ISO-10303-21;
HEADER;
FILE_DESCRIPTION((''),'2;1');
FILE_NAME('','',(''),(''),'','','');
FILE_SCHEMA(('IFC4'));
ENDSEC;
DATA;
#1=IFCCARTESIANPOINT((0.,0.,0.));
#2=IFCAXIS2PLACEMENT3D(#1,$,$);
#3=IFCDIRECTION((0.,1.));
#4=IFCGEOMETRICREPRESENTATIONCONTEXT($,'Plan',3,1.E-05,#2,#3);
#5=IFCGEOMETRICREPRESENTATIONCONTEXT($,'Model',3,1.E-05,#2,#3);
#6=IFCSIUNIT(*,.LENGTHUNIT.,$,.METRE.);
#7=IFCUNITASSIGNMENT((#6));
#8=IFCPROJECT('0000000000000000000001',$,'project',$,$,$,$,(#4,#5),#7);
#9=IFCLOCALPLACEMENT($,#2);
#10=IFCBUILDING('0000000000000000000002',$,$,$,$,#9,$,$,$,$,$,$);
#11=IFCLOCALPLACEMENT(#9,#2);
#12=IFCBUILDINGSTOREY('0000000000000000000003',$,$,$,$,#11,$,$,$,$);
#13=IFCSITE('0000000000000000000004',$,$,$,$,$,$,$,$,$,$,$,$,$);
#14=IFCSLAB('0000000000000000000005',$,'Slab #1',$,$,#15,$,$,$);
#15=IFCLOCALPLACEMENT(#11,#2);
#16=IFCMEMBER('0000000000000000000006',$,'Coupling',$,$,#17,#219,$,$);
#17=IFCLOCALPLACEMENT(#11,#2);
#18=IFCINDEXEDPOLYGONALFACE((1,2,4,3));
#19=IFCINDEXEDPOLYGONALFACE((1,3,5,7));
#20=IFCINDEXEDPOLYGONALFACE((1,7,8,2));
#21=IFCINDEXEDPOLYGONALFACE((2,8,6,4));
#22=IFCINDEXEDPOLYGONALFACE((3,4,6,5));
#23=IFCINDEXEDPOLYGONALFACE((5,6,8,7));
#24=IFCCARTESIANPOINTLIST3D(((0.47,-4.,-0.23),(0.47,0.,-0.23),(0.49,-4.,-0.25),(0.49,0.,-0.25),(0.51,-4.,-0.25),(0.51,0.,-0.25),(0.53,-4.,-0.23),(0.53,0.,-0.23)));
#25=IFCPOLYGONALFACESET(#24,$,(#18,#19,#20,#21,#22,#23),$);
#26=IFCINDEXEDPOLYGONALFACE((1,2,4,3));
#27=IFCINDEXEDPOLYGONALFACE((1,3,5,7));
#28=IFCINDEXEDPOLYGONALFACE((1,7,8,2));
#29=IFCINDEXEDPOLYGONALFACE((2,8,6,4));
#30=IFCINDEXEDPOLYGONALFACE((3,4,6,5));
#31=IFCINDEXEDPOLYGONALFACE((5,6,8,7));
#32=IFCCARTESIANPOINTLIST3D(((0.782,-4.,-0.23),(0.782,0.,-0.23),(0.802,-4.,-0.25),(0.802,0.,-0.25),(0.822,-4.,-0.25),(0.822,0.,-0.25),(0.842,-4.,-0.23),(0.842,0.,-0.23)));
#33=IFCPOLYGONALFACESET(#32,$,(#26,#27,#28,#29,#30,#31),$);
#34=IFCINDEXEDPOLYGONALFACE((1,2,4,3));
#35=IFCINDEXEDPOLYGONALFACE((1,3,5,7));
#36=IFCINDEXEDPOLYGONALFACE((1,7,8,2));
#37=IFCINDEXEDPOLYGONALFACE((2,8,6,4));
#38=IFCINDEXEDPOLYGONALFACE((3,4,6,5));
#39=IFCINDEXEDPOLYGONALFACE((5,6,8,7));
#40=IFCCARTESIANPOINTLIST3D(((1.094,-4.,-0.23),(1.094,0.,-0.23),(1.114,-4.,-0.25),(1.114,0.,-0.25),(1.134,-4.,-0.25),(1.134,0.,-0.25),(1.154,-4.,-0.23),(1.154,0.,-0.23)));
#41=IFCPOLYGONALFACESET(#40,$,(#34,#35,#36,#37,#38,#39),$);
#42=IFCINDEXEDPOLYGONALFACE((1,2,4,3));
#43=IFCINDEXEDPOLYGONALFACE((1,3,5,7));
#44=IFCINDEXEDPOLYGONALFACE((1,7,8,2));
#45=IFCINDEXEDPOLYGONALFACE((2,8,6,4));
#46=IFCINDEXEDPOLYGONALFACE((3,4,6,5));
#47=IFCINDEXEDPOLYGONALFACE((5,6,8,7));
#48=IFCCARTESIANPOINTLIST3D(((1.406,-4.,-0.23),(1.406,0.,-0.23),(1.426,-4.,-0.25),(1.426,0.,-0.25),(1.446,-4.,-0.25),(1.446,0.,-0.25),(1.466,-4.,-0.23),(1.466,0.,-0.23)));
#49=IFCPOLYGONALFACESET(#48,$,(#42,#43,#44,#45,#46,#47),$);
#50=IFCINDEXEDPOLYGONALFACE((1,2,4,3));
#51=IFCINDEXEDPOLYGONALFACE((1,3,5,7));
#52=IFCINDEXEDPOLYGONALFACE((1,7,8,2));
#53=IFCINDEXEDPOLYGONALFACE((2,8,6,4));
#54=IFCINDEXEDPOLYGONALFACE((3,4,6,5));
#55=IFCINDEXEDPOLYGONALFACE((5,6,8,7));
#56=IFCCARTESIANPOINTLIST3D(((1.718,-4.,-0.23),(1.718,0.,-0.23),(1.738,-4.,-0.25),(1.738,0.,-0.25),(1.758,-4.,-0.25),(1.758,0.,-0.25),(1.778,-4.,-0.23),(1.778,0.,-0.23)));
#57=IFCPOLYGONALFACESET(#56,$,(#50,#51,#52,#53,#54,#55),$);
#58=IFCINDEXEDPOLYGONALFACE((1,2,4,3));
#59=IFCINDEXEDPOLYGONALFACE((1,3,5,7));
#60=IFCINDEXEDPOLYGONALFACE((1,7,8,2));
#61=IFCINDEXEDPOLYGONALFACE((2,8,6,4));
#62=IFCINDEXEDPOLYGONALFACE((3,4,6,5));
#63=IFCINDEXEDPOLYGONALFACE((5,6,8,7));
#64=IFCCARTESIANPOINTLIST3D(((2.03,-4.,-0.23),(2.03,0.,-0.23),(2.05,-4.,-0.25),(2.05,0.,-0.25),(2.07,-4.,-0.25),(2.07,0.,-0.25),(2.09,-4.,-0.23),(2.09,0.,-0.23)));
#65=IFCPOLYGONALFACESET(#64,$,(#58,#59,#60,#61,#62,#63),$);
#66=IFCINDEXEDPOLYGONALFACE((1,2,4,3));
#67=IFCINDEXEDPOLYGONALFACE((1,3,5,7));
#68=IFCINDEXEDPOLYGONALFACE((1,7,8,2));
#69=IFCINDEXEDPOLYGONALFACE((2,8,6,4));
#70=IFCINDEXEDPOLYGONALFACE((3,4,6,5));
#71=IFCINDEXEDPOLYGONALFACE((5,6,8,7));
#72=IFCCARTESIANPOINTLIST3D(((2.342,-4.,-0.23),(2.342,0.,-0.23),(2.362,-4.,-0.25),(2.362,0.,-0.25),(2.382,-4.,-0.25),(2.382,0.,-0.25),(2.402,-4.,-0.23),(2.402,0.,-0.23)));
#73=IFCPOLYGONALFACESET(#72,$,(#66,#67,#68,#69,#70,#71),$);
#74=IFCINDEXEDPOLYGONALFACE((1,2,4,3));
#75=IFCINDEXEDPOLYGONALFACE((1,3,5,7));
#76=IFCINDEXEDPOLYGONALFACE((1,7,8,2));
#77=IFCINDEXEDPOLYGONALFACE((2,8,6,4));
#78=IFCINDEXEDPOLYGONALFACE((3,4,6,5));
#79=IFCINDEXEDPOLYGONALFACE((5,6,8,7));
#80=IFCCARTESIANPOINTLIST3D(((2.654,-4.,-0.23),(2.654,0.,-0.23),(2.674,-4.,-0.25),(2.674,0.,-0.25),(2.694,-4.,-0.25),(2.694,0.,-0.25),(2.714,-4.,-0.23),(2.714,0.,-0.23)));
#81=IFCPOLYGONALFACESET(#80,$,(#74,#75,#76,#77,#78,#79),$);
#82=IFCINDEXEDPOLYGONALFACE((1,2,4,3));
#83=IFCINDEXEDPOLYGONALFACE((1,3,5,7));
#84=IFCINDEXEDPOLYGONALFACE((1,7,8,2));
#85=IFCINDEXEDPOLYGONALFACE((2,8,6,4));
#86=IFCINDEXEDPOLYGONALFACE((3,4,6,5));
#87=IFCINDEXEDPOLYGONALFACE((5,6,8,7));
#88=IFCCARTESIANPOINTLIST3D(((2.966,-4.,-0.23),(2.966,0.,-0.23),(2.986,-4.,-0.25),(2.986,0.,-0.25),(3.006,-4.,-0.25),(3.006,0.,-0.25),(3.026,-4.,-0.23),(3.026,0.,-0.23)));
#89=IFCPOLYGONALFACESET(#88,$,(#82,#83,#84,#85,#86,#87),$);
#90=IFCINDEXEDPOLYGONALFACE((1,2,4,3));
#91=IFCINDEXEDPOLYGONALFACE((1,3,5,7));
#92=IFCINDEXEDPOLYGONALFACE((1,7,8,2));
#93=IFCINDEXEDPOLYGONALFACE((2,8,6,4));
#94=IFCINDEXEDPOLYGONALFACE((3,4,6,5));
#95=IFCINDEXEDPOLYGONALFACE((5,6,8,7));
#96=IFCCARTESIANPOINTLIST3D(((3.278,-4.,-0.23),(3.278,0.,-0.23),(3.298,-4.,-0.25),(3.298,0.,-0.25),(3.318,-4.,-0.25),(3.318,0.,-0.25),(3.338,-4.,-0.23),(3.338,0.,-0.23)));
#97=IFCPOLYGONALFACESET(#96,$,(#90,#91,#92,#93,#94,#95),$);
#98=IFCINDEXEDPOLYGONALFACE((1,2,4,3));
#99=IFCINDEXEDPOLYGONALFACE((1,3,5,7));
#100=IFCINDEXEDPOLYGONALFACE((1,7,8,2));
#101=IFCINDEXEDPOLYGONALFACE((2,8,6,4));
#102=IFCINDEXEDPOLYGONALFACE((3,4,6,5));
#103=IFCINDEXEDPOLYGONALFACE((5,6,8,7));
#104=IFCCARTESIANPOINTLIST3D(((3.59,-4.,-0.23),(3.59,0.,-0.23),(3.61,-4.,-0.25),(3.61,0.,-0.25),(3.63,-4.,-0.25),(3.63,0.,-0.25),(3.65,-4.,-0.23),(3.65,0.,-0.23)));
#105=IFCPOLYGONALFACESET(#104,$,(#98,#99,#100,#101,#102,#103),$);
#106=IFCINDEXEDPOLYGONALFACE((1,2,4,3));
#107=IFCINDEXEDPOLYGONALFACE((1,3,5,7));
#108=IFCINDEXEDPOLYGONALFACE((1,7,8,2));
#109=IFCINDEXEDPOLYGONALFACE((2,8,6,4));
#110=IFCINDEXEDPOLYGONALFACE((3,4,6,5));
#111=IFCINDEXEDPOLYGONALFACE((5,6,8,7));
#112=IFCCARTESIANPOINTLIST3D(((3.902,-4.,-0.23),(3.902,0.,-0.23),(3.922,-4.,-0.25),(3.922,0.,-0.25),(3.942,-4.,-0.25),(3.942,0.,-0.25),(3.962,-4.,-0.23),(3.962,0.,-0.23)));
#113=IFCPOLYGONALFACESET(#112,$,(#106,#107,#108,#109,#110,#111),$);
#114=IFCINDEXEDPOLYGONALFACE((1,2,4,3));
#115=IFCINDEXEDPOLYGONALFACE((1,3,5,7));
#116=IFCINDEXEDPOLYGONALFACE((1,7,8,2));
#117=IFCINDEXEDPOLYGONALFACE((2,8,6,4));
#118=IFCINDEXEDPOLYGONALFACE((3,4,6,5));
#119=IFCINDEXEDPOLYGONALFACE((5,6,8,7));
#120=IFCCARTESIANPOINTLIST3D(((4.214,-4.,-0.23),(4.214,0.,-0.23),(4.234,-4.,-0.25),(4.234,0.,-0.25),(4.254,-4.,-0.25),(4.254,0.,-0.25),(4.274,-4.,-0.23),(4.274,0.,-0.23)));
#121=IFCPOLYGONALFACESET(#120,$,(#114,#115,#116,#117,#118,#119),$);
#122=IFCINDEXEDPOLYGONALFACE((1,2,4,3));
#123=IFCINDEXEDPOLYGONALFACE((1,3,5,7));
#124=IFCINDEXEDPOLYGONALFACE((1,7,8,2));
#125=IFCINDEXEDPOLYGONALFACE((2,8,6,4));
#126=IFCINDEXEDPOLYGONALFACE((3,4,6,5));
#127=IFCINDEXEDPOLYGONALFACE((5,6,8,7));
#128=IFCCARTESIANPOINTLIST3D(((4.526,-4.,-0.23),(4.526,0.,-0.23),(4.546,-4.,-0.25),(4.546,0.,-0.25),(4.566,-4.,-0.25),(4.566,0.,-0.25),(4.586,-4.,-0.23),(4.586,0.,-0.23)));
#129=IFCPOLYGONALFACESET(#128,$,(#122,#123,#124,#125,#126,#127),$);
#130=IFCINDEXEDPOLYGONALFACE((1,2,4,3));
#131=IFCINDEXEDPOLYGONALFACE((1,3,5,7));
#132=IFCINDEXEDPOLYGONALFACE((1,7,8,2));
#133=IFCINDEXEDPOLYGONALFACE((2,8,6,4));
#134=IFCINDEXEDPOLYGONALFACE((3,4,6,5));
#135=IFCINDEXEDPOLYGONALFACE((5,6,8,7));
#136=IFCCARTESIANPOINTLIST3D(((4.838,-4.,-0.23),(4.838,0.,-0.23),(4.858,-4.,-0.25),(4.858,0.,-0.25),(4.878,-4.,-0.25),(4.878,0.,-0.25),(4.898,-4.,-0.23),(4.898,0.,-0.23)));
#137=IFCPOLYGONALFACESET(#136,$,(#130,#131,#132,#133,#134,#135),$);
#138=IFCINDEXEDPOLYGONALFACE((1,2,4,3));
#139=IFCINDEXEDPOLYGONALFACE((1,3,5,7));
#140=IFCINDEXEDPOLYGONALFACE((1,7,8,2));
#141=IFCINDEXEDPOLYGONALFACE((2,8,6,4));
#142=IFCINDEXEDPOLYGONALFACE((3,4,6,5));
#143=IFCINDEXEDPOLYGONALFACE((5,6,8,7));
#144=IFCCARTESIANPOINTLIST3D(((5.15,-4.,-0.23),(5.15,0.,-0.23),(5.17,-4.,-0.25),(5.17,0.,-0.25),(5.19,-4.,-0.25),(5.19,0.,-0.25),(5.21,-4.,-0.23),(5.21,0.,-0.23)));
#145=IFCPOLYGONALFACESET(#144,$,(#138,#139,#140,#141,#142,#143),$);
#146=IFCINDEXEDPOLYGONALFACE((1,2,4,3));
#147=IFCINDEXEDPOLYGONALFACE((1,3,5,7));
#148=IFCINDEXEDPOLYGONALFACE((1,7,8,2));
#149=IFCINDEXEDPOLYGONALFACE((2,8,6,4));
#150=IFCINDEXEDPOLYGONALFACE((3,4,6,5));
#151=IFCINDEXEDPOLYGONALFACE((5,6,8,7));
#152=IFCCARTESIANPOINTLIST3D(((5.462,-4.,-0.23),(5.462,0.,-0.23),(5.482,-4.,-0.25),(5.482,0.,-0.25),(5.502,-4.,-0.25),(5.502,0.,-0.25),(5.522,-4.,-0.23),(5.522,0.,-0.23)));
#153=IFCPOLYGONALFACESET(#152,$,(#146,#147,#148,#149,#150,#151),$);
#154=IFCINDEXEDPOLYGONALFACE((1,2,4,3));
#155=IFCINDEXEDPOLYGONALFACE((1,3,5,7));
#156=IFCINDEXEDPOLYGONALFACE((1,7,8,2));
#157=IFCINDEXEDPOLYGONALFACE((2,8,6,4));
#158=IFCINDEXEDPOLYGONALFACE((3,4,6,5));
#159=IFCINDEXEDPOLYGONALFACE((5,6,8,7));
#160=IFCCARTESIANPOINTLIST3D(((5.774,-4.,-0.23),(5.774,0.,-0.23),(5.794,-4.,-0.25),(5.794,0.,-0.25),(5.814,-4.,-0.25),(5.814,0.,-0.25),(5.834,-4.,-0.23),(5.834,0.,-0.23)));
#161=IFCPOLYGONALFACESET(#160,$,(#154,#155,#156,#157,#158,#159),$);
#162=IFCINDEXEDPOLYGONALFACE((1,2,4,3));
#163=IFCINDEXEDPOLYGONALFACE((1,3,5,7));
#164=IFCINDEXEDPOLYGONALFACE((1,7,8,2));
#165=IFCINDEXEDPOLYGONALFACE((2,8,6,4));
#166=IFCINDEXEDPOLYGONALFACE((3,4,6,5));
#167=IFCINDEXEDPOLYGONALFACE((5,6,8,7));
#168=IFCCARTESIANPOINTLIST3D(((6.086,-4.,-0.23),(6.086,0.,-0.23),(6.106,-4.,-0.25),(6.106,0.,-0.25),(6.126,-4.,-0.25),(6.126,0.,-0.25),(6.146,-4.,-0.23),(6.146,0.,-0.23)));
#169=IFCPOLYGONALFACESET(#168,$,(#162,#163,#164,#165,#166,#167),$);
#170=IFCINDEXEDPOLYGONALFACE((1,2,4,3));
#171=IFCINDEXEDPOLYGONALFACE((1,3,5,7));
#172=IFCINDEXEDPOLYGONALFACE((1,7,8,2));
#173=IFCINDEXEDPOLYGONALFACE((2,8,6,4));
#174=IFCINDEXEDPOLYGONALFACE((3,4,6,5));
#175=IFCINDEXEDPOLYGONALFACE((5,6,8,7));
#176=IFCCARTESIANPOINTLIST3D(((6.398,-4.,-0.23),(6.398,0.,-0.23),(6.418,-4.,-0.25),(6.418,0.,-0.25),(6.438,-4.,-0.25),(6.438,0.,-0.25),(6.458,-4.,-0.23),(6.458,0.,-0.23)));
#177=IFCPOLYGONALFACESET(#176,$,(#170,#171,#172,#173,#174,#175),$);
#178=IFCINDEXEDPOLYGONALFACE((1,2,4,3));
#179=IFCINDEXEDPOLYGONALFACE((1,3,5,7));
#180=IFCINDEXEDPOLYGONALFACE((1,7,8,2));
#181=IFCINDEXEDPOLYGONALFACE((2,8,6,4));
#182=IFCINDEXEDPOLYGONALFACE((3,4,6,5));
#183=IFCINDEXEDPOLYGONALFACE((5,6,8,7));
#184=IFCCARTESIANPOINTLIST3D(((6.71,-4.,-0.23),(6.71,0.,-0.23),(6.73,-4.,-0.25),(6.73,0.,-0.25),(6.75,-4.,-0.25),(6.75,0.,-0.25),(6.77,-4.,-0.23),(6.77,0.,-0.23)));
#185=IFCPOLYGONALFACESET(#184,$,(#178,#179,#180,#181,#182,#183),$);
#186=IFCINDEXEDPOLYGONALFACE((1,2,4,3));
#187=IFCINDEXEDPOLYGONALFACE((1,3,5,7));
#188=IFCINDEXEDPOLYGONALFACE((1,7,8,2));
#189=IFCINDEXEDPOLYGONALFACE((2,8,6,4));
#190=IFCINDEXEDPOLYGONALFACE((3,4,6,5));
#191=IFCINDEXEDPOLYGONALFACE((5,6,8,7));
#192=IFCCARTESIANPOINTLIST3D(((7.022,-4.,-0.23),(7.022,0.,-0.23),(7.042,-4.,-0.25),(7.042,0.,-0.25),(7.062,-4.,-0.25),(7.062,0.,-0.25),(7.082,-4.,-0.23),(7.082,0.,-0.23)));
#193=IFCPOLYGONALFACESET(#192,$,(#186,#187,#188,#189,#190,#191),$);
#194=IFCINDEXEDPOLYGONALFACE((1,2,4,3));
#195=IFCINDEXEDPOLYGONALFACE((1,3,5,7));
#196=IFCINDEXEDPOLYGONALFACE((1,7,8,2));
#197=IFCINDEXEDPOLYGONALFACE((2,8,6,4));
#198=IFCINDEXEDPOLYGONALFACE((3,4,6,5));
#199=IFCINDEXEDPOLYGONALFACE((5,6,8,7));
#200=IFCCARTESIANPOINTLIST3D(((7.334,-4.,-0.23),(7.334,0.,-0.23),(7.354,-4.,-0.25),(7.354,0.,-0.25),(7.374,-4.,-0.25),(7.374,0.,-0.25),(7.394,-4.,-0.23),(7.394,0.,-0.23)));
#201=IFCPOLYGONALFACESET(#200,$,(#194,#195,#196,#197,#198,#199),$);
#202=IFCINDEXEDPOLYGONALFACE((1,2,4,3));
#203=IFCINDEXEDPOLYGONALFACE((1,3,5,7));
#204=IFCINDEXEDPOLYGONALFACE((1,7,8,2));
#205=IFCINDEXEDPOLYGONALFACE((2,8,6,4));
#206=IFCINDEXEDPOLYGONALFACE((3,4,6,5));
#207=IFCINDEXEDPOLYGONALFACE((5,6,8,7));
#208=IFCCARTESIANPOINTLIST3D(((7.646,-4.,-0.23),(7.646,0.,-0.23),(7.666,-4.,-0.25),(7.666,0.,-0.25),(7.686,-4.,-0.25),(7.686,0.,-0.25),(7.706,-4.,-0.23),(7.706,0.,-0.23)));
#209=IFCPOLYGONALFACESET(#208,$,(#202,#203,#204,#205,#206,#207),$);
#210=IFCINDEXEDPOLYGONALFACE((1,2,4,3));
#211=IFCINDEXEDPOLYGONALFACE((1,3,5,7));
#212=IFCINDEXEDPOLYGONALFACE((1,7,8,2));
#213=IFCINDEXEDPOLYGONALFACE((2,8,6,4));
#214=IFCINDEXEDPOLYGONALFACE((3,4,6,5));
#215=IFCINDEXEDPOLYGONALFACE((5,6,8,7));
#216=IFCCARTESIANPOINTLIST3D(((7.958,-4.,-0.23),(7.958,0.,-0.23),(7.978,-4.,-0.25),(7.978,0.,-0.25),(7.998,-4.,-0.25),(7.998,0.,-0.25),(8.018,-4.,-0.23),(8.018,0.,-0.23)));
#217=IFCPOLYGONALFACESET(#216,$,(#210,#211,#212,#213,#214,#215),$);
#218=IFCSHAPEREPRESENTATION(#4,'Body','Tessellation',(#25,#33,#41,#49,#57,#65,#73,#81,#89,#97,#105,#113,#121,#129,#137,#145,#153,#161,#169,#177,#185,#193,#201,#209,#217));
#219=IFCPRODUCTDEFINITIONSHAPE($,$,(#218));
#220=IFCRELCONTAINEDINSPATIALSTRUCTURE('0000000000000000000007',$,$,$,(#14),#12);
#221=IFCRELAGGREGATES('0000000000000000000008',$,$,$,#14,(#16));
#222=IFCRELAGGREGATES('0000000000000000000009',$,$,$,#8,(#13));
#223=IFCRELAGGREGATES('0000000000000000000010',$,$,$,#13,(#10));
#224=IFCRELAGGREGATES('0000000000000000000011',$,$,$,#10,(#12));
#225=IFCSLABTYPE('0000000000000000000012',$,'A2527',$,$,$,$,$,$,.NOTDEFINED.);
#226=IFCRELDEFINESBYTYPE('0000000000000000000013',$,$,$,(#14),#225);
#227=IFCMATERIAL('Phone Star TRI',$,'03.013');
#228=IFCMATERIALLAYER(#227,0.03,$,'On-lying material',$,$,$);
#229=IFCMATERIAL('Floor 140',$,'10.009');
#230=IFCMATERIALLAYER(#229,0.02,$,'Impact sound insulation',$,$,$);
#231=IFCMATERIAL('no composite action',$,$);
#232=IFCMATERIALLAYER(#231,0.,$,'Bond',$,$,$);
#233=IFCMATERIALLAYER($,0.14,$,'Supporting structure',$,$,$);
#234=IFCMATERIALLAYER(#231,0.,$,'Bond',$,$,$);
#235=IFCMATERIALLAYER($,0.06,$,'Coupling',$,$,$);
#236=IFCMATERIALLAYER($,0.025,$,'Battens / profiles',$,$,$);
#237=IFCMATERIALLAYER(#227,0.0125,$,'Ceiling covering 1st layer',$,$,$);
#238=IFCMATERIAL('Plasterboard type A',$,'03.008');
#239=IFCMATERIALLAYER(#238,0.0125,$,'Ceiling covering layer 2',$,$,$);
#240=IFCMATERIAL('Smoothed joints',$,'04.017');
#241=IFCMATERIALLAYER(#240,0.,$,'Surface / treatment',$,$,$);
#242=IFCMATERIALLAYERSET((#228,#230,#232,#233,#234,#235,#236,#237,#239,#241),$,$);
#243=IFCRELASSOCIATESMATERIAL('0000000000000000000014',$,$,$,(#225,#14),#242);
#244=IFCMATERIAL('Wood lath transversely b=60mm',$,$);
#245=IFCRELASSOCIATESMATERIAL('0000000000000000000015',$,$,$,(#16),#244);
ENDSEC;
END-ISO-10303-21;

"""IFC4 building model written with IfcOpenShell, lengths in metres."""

from ifc_helpers import new_model, si_unit, direction, frame, origin, place, context, project, spatial, polyline, outline, extrude, material, layer, layer_set, type_object, element, aggregate, save


model = new_model("IFC4")

# Units and contexts
plan_context = context("Plan", 3, precision=1e-05, world=origin(), true_north=direction((0.0, 1.0)))
model_context = context("Model", 3, precision=1e-05, world=origin(), true_north=direction((0.0, 1.0)))
ifc_project = project(units=[si_unit("LENGTHUNIT", "METRE")], contexts=[plan_context, model_context])

# Site, building, storey
site = spatial("IfcSite", under=ifc_project)
building_placement = place(None, origin())
building = spatial("IfcBuilding", under=site, at=building_placement)
storey_placement = place(building_placement, origin())
storey = spatial("IfcBuildingStorey", under=building, at=storey_placement)

# Slab, member
ifc_material_1 = material(Name="Phone Star TRI", Category="03.013")
ifc_layer_1 = layer(ifc_material_1, 0.03, Name="On-lying material")
ifc_material_2 = material(Name="Floor 140", Category="10.009")
ifc_layer_2 = layer(ifc_material_2, 0.02, Name="Impact sound insulation")
ifc_material_3 = material(Name="no composite action")
ifc_layer_3 = layer(ifc_material_3, 0.0, Name="Bond")
ifc_layer_4 = layer(None, 0.14, Name="Supporting structure")
ifc_layer_5 = layer(ifc_material_3, 0.0, Name="Bond")
ifc_layer_6 = layer(None, 0.06, Name="Coupling")
ifc_layer_7 = layer(None, 0.025, Name="Battens / profiles")
ifc_layer_8 = layer(ifc_material_1, 0.0125, Name="Ceiling covering 1st layer")
ifc_material_4 = material(Name="Plasterboard type A", Category="03.008")
ifc_layer_9 = layer(ifc_material_4, 0.0125, Name="Ceiling covering layer 2")
ifc_material_5 = material(Name="Smoothed joints", Category="04.017")
ifc_layer_10 = layer(ifc_material_5, 0.0, Name="Surface / treatment")
ifc_layer_set = layer_set([ifc_layer_1, ifc_layer_2, ifc_layer_3, ifc_layer_4, ifc_layer_5, ifc_layer_6, ifc_layer_7, ifc_layer_8, ifc_layer_9, ifc_layer_10])
slab_type = type_object("IfcSlabType", Name="A2527", PredefinedType="NOTDEFINED", material=ifc_layer_set)
slab_placement = place(None, frame((0.0, 0.0, 0.0), z_axis=(0.0, 0.0, -1.0), x_axis=(1.0, 0.0, 0.0)))
slab = element("IfcSlab", 1, at=slab_placement, inside=storey, type_object=slab_type, material=ifc_layer_set, Name="Slab #1")
ifc_material_6 = material(Name="Wood lath transversely b=60mm")
member_1_placement = place(slab_placement, origin())
member_1 = element("IfcMember", 2, at=member_1_placement, material=ifc_material_6, Name="Coupling", context=plan_context, shape_type="SweptSolid", body=[
    extrude(outline(polyline([(0.0, 0.0), (0.06, 0.0), (0.04, 0.02), (0.02, 0.02), (0.0, 0.0)])), frame((0.47, 4.0, 0.23), z_axis=(0.0, -1.0, 0.0), x_axis=(1.0, 0.0, 0.0)), (0.0, 0.0, 1.0), 4.0),
    extrude(outline(polyline([(0.0, 0.0), (0.06, 0.0), (0.04, 0.02), (0.02, 0.02), (0.0, 0.0)])), frame((0.782, 4.0, 0.23), z_axis=(0.0, -1.0, 0.0), x_axis=(1.0, 0.0, 0.0)), (0.0, 0.0, 1.0), 4.0),
    extrude(outline(polyline([(0.0, 0.0), (0.06, 0.0), (0.04, 0.02), (0.02, 0.02), (0.0, 0.0)])), frame((1.094, 4.0, 0.23), z_axis=(0.0, -1.0, 0.0), x_axis=(1.0, 0.0, 0.0)), (0.0, 0.0, 1.0), 4.0),
    extrude(outline(polyline([(0.0, 0.0), (0.06, 0.0), (0.04, 0.02), (0.02, 0.02), (0.0, 0.0)])), frame((1.406, 4.0, 0.23), z_axis=(0.0, -1.0, 0.0), x_axis=(1.0, 0.0, 0.0)), (0.0, 0.0, 1.0), 4.0),
    extrude(outline(polyline([(0.0, 0.0), (0.06, 0.0), (0.04, 0.02), (0.02, 0.02), (0.0, 0.0)])), frame((1.718, 4.0, 0.23), z_axis=(0.0, -1.0, 0.0), x_axis=(1.0, 0.0, 0.0)), (0.0, 0.0, 1.0), 4.0),
    extrude(outline(polyline([(0.0, 0.0), (0.06, 0.0), (0.04, 0.02), (0.02, 0.02), (0.0, 0.0)])), frame((2.03, 4.0, 0.23), z_axis=(0.0, -1.0, 0.0), x_axis=(1.0, 0.0, 0.0)), (0.0, 0.0, 1.0), 4.0),
    extrude(outline(polyline([(0.0, 0.0), (0.06, 0.0), (0.04, 0.02), (0.02, 0.02), (0.0, 0.0)])), frame((2.342, 4.0, 0.23), z_axis=(0.0, -1.0, 0.0), x_axis=(1.0, 0.0, 0.0)), (0.0, 0.0, 1.0), 4.0),
    extrude(outline(polyline([(0.0, 0.0), (0.06, 0.0), (0.04, 0.02), (0.02, 0.02), (0.0, 0.0)])), frame((2.654, 4.0, 0.23), z_axis=(0.0, -1.0, 0.0), x_axis=(1.0, 0.0, 0.0)), (0.0, 0.0, 1.0), 4.0),
    extrude(outline(polyline([(0.0, 0.0), (0.06, 0.0), (0.04, 0.02), (0.02, 0.02), (0.0, 0.0)])), frame((2.966, 4.0, 0.23), z_axis=(0.0, -1.0, 0.0), x_axis=(1.0, 0.0, 0.0)), (0.0, 0.0, 1.0), 4.0),
    extrude(outline(polyline([(0.0, 0.0), (0.06, 0.0), (0.04, 0.02), (0.02, 0.02), (0.0, 0.0)])), frame((3.278, 4.0, 0.23), z_axis=(0.0, -1.0, 0.0), x_axis=(1.0, 0.0, 0.0)), (0.0, 0.0, 1.0), 4.0),
    extrude(outline(polyline([(0.0, 0.0), (0.06, 0.0), (0.04, 0.02), (0.02, 0.02), (0.0, 0.0)])), frame((3.59, 4.0, 0.23), z_axis=(0.0, -1.0, 0.0), x_axis=(1.0, 0.0, 0.0)), (0.0, 0.0, 1.0), 4.0),
    extrude(outline(polyline([(0.0, 0.0), (0.06, 0.0), (0.04, 0.02), (0.02, 0.02), (0.0, 0.0)])), frame((3.902, 4.0, 0.23), z_axis=(0.0, -1.0, 0.0), x_axis=(1.0, 0.0, 0.0)), (0.0, 0.0, 1.0), 4.0),
    extrude(outline(polyline([(0.0, 0.0), (0.06, 0.0), (0.04, 0.02), (0.02, 0.02), (0.0, 0.0)])), frame((4.214, 4.0, 0.23), z_axis=(0.0, -1.0, 0.0), x_axis=(1.0, 0.0, 0.0)), (0.0, 0.0, 1.0), 4.0),
    extrude(outline(polyline([(0.0, 0.0), (0.06, 0.0), (0.04, 0.02), (0.02, 0.02), (0.0, 0.0)])), frame((4.526, 4.0, 0.23), z_axis=(0.0, -1.0, 0.0), x_axis=(1.0, 0.0, 0.0)), (0.0, 0.0, 1.0), 4.0),
    extrude(outline(polyline([(0.0, 0.0), (0.06, 0.0), (0.04, 0.02), (0.02, 0.02), (0.0, 0.0)])), frame((4.838, 4.0, 0.23), z_axis=(0.0, -1.0, 0.0), x_axis=(1.0, 0.0, 0.0)), (0.0, 0.0, 1.0), 4.0),
    extrude(outline(polyline([(0.0, 0.0), (0.06, 0.0), (0.04, 0.02), (0.02, 0.02), (0.0, 0.0)])), frame((5.15, 4.0, 0.23), z_axis=(0.0, -1.0, 0.0), x_axis=(1.0, 0.0, 0.0)), (0.0, 0.0, 1.0), 4.0),
    extrude(outline(polyline([(0.0, 0.0), (0.06, 0.0), (0.04, 0.02), (0.02, 0.02), (0.0, 0.0)])), frame((5.462, 4.0, 0.23), z_axis=(0.0, -1.0, 0.0), x_axis=(1.0, 0.0, 0.0)), (0.0, 0.0, 1.0), 4.0),
    extrude(outline(polyline([(0.0, 0.0), (0.06, 0.0), (0.04, 0.02), (0.02, 0.02), (0.0, 0.0)])), frame((5.774, 4.0, 0.23), z_axis=(0.0, -1.0, 0.0), x_axis=(1.0, 0.0, 0.0)), (0.0, 0.0, 1.0), 4.0),
    extrude(outline(polyline([(0.0, 0.0), (0.06, 0.0), (0.04, 0.02), (0.02, 0.02), (0.0, 0.0)])), frame((6.086, 4.0, 0.23), z_axis=(0.0, -1.0, 0.0), x_axis=(1.0, 0.0, 0.0)), (0.0, 0.0, 1.0), 4.0),
    extrude(outline(polyline([(0.0, 0.0), (0.06, 0.0), (0.04, 0.02), (0.02, 0.02), (0.0, 0.0)])), frame((6.398, 4.0, 0.23), z_axis=(0.0, -1.0, 0.0), x_axis=(1.0, 0.0, 0.0)), (0.0, 0.0, 1.0), 4.0),
    extrude(outline(polyline([(0.0, 0.0), (0.06, 0.0), (0.04, 0.02), (0.02, 0.02), (0.0, 0.0)])), frame((6.71, 4.0, 0.23), z_axis=(0.0, -1.0, 0.0), x_axis=(1.0, 0.0, 0.0)), (0.0, 0.0, 1.0), 4.0),
    extrude(outline(polyline([(0.0, 0.0), (0.06, 0.0), (0.04, 0.02), (0.02, 0.02), (0.0, 0.0)])), frame((7.022, 4.0, 0.23), z_axis=(0.0, -1.0, 0.0), x_axis=(1.0, 0.0, 0.0)), (0.0, 0.0, 1.0), 4.0),
    extrude(outline(polyline([(0.0, 0.0), (0.06, 0.0), (0.04, 0.02), (0.02, 0.02), (0.0, 0.0)])), frame((7.334, 4.0, 0.23), z_axis=(0.0, -1.0, 0.0), x_axis=(1.0, 0.0, 0.0)), (0.0, 0.0, 1.0), 4.0),
    extrude(outline(polyline([(0.0, 0.0), (0.06, 0.0), (0.04, 0.02), (0.02, 0.02), (0.0, 0.0)])), frame((7.646, 4.0, 0.23), z_axis=(0.0, -1.0, 0.0), x_axis=(1.0, 0.0, 0.0)), (0.0, 0.0, 1.0), 4.0),
    extrude(outline(polyline([(0.0, 0.0), (0.06, 0.0), (0.04, 0.02), (0.02, 0.02), (0.0, 0.0)])), frame((7.958, 4.0, 0.23), z_axis=(0.0, -1.0, 0.0), x_axis=(1.0, 0.0, 0.0)), (0.0, 0.0, 1.0), 4.0),
])
aggregate(slab, [member_1])

save(model, "model.ifc")
